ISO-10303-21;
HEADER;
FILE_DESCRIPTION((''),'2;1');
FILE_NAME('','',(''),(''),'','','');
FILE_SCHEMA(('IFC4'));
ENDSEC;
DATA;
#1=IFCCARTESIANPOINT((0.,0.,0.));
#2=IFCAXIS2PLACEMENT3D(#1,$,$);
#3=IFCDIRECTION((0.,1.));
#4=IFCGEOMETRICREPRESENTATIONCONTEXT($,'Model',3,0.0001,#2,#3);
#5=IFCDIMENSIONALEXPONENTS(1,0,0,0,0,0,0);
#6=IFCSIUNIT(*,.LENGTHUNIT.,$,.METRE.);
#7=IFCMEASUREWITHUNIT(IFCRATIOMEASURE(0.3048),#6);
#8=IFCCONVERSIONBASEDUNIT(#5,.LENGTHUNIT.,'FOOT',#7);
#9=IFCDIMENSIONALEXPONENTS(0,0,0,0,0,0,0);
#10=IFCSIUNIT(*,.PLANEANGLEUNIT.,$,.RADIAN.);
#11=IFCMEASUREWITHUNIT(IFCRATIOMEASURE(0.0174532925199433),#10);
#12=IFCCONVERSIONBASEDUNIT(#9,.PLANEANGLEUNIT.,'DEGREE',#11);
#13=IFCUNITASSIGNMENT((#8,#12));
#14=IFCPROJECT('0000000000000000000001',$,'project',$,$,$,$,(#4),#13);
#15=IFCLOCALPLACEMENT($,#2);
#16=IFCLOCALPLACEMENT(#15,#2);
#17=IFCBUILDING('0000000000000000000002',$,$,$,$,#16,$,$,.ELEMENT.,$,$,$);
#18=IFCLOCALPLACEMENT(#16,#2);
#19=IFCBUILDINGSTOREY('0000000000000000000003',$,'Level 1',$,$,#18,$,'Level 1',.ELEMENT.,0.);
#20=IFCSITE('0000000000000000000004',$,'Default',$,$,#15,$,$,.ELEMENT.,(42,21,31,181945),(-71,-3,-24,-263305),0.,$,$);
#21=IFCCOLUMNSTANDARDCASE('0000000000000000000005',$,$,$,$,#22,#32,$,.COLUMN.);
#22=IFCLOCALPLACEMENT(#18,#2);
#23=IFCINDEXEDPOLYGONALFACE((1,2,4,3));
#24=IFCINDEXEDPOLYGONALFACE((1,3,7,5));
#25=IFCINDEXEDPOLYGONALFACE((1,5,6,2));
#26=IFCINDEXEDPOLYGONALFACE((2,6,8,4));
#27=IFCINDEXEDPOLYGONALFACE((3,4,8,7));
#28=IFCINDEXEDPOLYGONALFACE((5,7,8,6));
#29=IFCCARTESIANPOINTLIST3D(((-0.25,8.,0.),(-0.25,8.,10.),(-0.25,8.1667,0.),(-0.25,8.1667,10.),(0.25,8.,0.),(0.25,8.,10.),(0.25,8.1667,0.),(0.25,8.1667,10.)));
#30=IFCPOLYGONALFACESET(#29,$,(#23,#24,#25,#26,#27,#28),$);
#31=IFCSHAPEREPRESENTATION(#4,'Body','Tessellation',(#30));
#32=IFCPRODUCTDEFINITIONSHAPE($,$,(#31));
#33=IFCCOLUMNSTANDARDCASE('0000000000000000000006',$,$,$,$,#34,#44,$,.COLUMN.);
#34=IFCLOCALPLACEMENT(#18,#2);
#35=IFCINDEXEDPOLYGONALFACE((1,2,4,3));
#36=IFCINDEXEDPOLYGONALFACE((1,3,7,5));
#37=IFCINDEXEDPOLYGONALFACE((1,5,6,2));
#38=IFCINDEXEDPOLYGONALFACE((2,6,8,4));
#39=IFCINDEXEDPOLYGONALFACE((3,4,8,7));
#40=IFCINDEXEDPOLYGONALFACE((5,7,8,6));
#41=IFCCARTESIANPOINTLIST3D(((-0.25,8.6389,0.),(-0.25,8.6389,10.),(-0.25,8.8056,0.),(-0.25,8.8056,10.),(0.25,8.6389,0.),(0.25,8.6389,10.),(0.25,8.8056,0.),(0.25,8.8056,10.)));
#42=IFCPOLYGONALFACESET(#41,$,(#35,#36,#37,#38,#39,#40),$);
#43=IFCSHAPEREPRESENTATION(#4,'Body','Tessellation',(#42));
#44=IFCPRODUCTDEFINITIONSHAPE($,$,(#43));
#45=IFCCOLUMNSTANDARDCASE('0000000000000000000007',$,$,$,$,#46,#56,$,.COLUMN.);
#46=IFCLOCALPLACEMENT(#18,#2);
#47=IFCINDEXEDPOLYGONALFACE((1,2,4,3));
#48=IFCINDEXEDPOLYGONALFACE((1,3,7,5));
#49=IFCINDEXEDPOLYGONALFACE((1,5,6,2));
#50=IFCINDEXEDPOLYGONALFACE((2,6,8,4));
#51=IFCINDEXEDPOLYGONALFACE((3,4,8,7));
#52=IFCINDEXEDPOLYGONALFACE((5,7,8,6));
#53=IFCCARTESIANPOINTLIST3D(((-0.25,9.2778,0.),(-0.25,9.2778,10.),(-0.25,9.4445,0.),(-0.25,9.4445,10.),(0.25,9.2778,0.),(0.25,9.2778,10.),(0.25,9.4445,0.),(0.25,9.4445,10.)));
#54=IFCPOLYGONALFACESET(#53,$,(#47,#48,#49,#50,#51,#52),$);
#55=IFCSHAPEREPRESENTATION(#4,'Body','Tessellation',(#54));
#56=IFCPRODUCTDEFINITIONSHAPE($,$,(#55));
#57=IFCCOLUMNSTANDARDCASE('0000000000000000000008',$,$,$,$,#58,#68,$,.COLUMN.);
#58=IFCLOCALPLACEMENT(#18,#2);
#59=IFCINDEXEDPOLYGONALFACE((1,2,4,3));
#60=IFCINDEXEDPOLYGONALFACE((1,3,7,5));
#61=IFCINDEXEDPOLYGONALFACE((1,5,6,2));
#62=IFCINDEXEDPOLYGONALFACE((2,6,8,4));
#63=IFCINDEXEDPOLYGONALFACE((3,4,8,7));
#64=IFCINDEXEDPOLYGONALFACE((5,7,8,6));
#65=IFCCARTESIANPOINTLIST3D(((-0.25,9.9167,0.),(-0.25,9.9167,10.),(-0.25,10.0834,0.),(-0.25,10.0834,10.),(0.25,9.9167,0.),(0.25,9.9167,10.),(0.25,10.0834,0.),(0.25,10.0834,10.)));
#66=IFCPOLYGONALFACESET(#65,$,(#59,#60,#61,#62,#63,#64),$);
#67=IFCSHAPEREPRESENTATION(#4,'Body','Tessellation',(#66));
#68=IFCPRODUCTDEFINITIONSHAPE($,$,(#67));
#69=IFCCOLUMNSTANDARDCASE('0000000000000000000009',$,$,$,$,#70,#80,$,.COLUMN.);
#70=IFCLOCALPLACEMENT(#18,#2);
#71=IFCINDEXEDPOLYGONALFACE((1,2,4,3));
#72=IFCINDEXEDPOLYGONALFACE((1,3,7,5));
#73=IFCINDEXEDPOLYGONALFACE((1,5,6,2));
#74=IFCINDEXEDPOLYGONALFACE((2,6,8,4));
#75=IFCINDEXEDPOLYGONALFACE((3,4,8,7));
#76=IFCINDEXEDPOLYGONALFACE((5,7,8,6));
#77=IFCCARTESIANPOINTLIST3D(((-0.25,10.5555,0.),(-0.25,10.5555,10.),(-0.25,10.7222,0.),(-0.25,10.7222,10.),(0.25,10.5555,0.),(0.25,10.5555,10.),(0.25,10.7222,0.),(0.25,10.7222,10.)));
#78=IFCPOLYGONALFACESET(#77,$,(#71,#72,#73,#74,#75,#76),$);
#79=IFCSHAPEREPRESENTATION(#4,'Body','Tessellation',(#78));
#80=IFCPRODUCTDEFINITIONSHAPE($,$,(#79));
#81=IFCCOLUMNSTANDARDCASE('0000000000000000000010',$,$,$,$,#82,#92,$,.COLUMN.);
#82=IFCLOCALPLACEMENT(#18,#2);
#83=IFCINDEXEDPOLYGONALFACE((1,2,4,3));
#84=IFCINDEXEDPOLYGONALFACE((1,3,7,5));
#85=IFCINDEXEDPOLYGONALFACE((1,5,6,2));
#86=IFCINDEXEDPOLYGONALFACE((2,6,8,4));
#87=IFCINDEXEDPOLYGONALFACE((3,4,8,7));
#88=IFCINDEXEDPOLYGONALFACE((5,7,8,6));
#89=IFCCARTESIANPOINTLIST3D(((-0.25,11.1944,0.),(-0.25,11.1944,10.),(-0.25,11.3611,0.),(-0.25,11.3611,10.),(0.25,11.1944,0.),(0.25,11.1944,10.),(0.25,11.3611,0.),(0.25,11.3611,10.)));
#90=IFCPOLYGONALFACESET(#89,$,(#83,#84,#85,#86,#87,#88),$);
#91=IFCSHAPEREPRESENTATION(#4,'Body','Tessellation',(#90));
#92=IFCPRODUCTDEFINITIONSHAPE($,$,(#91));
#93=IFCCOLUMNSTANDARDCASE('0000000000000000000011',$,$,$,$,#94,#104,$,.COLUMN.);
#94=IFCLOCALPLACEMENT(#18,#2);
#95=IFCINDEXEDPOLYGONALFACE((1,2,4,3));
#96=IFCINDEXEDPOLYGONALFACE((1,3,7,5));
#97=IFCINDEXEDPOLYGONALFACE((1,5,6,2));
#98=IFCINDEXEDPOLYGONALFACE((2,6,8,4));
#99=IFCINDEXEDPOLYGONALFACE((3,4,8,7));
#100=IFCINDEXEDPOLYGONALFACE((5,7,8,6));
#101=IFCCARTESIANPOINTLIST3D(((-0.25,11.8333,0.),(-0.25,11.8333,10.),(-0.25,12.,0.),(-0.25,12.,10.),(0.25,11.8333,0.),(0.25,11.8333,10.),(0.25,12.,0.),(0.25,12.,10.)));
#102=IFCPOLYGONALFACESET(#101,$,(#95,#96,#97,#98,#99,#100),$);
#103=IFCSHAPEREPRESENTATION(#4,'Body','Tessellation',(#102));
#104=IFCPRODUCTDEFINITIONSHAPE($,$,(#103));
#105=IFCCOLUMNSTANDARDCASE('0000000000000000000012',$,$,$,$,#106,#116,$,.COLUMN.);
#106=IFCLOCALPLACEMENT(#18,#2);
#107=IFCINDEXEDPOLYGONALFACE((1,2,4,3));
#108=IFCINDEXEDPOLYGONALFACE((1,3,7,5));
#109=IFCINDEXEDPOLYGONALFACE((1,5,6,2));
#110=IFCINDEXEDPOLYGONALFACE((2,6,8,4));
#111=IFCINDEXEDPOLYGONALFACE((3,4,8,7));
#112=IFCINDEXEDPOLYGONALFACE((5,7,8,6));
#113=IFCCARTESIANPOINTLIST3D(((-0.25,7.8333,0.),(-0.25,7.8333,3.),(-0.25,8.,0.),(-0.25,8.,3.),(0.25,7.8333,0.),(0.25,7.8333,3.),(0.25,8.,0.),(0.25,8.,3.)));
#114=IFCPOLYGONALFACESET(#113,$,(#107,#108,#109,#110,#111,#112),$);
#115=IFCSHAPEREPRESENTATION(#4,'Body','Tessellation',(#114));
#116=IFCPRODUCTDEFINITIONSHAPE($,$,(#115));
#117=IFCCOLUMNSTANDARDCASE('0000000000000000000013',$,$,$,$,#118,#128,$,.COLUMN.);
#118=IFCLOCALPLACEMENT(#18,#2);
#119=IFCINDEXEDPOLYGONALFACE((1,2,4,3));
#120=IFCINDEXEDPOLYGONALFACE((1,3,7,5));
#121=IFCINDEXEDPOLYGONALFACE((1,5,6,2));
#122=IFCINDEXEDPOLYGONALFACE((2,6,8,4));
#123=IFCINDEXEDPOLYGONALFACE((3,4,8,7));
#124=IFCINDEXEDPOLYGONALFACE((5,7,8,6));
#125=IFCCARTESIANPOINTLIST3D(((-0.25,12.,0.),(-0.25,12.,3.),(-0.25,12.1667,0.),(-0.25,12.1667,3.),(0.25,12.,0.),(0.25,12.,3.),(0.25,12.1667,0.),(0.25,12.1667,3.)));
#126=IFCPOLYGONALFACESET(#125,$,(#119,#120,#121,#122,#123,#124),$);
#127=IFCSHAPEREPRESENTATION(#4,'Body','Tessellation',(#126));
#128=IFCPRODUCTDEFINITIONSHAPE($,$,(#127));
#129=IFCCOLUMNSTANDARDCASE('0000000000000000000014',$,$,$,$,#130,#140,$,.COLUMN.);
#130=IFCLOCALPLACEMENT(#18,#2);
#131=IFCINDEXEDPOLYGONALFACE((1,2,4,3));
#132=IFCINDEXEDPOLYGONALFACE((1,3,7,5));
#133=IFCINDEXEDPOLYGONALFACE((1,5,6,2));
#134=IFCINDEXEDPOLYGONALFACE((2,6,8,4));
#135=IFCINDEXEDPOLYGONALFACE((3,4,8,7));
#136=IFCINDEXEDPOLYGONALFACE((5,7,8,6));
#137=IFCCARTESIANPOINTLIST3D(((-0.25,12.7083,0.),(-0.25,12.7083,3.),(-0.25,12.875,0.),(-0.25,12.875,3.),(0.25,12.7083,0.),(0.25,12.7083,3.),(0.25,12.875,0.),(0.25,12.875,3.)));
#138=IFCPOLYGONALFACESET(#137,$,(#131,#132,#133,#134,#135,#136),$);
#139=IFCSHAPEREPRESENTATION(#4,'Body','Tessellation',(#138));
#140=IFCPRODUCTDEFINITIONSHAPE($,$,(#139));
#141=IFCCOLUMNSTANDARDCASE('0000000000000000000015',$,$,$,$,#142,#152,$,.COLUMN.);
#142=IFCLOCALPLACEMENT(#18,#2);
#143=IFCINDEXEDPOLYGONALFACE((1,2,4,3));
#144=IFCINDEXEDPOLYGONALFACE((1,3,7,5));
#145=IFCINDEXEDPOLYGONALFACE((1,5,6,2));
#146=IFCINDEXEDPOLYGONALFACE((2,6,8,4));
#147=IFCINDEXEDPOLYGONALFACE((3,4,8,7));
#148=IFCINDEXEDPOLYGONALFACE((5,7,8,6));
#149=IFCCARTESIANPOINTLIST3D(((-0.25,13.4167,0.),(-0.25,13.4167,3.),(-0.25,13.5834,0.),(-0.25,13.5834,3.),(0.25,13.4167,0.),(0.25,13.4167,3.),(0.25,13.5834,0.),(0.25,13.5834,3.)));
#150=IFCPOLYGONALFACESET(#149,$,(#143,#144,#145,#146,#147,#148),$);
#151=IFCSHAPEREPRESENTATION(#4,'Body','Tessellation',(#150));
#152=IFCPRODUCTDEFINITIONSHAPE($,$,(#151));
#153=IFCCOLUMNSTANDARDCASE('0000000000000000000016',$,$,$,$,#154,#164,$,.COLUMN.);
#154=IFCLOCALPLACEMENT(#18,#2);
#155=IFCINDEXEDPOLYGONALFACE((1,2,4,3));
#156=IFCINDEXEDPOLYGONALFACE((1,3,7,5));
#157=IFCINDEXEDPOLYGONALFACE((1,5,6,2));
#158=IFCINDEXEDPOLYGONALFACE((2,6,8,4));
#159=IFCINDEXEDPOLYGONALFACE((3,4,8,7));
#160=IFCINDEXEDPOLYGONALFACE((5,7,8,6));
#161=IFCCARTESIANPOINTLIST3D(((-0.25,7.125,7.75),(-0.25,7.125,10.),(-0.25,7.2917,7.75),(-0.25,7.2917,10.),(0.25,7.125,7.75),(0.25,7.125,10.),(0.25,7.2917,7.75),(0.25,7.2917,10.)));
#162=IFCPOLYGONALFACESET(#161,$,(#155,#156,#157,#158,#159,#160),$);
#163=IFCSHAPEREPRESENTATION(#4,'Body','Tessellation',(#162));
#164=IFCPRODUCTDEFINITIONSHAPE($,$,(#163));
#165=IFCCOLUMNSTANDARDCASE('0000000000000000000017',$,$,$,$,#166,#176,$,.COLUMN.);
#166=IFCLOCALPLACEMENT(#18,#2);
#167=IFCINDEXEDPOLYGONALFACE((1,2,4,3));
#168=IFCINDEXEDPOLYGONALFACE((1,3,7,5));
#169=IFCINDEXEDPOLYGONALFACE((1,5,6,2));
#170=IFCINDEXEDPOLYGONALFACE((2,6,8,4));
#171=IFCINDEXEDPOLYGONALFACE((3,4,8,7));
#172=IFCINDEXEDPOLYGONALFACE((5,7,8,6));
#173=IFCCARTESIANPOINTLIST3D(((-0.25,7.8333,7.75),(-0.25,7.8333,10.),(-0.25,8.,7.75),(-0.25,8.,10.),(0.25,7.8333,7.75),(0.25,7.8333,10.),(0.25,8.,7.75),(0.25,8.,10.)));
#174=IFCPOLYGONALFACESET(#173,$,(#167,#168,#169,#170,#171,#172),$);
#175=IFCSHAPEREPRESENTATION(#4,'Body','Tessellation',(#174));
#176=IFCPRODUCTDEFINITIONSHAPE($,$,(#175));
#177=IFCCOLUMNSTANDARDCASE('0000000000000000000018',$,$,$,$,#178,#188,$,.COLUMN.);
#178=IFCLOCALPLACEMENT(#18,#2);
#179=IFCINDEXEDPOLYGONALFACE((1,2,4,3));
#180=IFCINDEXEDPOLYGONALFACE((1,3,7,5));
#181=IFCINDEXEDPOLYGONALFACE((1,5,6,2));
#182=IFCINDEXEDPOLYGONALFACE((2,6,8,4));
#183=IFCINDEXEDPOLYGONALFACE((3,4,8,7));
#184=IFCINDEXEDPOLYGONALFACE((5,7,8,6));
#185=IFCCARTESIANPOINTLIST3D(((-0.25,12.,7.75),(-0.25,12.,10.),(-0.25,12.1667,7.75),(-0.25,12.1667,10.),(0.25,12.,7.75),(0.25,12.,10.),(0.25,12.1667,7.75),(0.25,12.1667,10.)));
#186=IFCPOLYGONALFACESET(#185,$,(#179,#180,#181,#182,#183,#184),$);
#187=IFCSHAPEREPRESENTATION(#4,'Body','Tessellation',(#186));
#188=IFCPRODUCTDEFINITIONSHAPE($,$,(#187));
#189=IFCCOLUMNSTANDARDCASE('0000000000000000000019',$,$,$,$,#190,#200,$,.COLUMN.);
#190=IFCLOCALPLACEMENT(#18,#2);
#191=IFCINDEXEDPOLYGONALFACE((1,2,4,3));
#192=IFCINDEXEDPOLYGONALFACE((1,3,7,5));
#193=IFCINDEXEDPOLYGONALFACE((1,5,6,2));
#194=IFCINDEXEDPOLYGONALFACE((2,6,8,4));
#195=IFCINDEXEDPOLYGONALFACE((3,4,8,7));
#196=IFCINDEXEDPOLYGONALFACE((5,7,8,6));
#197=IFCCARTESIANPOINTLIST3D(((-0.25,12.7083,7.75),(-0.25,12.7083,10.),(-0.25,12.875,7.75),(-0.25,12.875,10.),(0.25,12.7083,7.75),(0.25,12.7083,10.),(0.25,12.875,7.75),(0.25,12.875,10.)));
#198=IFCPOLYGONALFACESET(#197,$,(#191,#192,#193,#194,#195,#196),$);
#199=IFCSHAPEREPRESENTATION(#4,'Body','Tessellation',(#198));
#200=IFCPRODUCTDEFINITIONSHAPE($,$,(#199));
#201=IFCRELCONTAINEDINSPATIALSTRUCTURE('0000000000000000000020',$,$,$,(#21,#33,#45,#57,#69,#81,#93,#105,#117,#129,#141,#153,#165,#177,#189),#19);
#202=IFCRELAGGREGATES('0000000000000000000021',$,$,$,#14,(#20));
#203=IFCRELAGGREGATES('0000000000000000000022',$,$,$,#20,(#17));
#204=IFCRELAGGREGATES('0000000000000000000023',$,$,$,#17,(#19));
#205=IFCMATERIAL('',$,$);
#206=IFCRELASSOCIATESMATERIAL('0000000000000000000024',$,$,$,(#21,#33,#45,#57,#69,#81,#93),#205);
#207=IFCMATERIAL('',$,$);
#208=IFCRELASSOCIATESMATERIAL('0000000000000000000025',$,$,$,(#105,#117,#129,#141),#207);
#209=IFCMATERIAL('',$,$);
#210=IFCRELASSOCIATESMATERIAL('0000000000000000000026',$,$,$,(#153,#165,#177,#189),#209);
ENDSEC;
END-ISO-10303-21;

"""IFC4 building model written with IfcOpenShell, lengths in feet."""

from ifc_helpers import new_model, entity, si_unit, converted_unit, direction, frame, origin, place, context, project, spatial, rectangle, extrude, material, element, save


model = new_model("IFC4")

# Units and contexts
model_context = context("Model", 3, precision=0.0001, world=origin(), true_north=direction((0.0, 1.0)))
ifc_project = project(units=[converted_unit("LENGTHUNIT", "FOOT", entity("IfcRatioMeasure", 0.3048), si_unit("LENGTHUNIT", "METRE"), dimensions=[1, 0, 0, 0, 0, 0, 0]), converted_unit("PLANEANGLEUNIT", "DEGREE", entity("IfcRatioMeasure", 0.0174532925199433), si_unit("PLANEANGLEUNIT", "RADIAN"), dimensions=[0, 0, 0, 0, 0, 0, 0])], contexts=[model_context])

# Site, building, storey
site_placement = place(None, origin())
site = spatial("IfcSite", under=ifc_project, at=site_placement, Name="Default", CompositionType="ELEMENT", RefLatitude=(42, 21, 31, 181945), RefLongitude=(-71, -3, -24, -263305), RefElevation=0.0)
building_placement = place(site_placement, origin())
building = spatial("IfcBuilding", under=site, at=building_placement, CompositionType="ELEMENT")
storey_placement = place(building_placement, origin())
storey = spatial("IfcBuildingStorey", under=building, at=storey_placement, Name="Level 1", LongName="Level 1", CompositionType="ELEMENT", Elevation=0.0)

# Columns
ifc_material_1 = material(Name="")
placement = place(storey_placement, frame((0.0, -0.25, 0.0), z_axis=(0.0, 0.0, 1.0), x_axis=(0.0, 1.0, 0.0)))
for number, where, z_axis, x_axis in (
    (1, (8.3334, 0.0, 0.0), (0.0, 0.0, 1.0), (1.0, 0.0, 0.0)),
    (2, (8.9722, 0.0, 0.0), (0.0, 0.0, 1.0), (1.0, 0.0, 0.0)),
    (3, (9.6111, 0.0, 0.0), (0.0, 0.0, 1.0), (1.0, 0.0, 0.0)),
    (4, (10.25, 0.0, 0.0), (0.0, 0.0, 1.0), (1.0, 0.0, 0.0)),
    (5, (10.8889, 0.0, 0.0), (0.0, 0.0, 1.0), (1.0, 0.0, 0.0)),
    (6, (11.5278, 0.0, 0.0), (0.0, 0.0, 1.0), (1.0, 0.0, 0.0)),
    (7, (12.1667, 0.0, 0.0), (0.0, 0.0, 1.0), (1.0, 0.0, 0.0)),
):
    element("IfcColumnStandardCase", number, at=place(placement, frame(where, z_axis=z_axis, x_axis=x_axis)), inside=storey, material=ifc_material_1, PredefinedType="COLUMN", context=model_context, shape_type="SweptSolid", body=[
        extrude(rectangle(XDim=0.1667, YDim=0.5), origin(), (0.0, 0.0, 1.0), 10.0),
    ])
ifc_material_2 = material(Name="")
for number, where, z_axis, x_axis in (
    (8, (8.1667, 0.0, 0.0), (0.0, 0.0, 1.0), (1.0, 0.0, 0.0)),
    (9, (12.3334, 0.0, 0.0), (0.0, 0.0, 1.0), (1.0, 0.0, 0.0)),
    (10, (13.0417, 0.0, 0.0), (0.0, 0.0, 1.0), (1.0, 0.0, 0.0)),
    (11, (13.75, 0.0, 0.0), (0.0, 0.0, 1.0), (1.0, 0.0, 0.0)),
):
    element("IfcColumnStandardCase", number, at=place(placement, frame(where, z_axis=z_axis, x_axis=x_axis)), inside=storey, material=ifc_material_2, PredefinedType="COLUMN", context=model_context, shape_type="SweptSolid", body=[
        extrude(rectangle(XDim=0.1667, YDim=0.5), origin(), (0.0, 0.0, 1.0), 3.0),
    ])
ifc_material_3 = material(Name="")
for number, where, z_axis, x_axis in (
    (12, (7.4583, 0.0, 7.75), (0.0, 0.0, 1.0), (1.0, 0.0, 0.0)),
    (13, (8.1667, 0.0, 7.75), (0.0, 0.0, 1.0), (1.0, 0.0, 0.0)),
    (14, (12.3334, 0.0, 7.75), (0.0, 0.0, 1.0), (1.0, 0.0, 0.0)),
    (15, (13.0417, 0.0, 7.75), (0.0, 0.0, 1.0), (1.0, 0.0, 0.0)),
):
    element("IfcColumnStandardCase", number, at=place(placement, frame(where, z_axis=z_axis, x_axis=x_axis)), inside=storey, material=ifc_material_3, PredefinedType="COLUMN", context=model_context, shape_type="SweptSolid", body=[
        extrude(rectangle(XDim=0.1667, YDim=0.5), origin(), (0.0, 0.0, 1.0), 2.25),
    ])

save(model, "model.ifc")
